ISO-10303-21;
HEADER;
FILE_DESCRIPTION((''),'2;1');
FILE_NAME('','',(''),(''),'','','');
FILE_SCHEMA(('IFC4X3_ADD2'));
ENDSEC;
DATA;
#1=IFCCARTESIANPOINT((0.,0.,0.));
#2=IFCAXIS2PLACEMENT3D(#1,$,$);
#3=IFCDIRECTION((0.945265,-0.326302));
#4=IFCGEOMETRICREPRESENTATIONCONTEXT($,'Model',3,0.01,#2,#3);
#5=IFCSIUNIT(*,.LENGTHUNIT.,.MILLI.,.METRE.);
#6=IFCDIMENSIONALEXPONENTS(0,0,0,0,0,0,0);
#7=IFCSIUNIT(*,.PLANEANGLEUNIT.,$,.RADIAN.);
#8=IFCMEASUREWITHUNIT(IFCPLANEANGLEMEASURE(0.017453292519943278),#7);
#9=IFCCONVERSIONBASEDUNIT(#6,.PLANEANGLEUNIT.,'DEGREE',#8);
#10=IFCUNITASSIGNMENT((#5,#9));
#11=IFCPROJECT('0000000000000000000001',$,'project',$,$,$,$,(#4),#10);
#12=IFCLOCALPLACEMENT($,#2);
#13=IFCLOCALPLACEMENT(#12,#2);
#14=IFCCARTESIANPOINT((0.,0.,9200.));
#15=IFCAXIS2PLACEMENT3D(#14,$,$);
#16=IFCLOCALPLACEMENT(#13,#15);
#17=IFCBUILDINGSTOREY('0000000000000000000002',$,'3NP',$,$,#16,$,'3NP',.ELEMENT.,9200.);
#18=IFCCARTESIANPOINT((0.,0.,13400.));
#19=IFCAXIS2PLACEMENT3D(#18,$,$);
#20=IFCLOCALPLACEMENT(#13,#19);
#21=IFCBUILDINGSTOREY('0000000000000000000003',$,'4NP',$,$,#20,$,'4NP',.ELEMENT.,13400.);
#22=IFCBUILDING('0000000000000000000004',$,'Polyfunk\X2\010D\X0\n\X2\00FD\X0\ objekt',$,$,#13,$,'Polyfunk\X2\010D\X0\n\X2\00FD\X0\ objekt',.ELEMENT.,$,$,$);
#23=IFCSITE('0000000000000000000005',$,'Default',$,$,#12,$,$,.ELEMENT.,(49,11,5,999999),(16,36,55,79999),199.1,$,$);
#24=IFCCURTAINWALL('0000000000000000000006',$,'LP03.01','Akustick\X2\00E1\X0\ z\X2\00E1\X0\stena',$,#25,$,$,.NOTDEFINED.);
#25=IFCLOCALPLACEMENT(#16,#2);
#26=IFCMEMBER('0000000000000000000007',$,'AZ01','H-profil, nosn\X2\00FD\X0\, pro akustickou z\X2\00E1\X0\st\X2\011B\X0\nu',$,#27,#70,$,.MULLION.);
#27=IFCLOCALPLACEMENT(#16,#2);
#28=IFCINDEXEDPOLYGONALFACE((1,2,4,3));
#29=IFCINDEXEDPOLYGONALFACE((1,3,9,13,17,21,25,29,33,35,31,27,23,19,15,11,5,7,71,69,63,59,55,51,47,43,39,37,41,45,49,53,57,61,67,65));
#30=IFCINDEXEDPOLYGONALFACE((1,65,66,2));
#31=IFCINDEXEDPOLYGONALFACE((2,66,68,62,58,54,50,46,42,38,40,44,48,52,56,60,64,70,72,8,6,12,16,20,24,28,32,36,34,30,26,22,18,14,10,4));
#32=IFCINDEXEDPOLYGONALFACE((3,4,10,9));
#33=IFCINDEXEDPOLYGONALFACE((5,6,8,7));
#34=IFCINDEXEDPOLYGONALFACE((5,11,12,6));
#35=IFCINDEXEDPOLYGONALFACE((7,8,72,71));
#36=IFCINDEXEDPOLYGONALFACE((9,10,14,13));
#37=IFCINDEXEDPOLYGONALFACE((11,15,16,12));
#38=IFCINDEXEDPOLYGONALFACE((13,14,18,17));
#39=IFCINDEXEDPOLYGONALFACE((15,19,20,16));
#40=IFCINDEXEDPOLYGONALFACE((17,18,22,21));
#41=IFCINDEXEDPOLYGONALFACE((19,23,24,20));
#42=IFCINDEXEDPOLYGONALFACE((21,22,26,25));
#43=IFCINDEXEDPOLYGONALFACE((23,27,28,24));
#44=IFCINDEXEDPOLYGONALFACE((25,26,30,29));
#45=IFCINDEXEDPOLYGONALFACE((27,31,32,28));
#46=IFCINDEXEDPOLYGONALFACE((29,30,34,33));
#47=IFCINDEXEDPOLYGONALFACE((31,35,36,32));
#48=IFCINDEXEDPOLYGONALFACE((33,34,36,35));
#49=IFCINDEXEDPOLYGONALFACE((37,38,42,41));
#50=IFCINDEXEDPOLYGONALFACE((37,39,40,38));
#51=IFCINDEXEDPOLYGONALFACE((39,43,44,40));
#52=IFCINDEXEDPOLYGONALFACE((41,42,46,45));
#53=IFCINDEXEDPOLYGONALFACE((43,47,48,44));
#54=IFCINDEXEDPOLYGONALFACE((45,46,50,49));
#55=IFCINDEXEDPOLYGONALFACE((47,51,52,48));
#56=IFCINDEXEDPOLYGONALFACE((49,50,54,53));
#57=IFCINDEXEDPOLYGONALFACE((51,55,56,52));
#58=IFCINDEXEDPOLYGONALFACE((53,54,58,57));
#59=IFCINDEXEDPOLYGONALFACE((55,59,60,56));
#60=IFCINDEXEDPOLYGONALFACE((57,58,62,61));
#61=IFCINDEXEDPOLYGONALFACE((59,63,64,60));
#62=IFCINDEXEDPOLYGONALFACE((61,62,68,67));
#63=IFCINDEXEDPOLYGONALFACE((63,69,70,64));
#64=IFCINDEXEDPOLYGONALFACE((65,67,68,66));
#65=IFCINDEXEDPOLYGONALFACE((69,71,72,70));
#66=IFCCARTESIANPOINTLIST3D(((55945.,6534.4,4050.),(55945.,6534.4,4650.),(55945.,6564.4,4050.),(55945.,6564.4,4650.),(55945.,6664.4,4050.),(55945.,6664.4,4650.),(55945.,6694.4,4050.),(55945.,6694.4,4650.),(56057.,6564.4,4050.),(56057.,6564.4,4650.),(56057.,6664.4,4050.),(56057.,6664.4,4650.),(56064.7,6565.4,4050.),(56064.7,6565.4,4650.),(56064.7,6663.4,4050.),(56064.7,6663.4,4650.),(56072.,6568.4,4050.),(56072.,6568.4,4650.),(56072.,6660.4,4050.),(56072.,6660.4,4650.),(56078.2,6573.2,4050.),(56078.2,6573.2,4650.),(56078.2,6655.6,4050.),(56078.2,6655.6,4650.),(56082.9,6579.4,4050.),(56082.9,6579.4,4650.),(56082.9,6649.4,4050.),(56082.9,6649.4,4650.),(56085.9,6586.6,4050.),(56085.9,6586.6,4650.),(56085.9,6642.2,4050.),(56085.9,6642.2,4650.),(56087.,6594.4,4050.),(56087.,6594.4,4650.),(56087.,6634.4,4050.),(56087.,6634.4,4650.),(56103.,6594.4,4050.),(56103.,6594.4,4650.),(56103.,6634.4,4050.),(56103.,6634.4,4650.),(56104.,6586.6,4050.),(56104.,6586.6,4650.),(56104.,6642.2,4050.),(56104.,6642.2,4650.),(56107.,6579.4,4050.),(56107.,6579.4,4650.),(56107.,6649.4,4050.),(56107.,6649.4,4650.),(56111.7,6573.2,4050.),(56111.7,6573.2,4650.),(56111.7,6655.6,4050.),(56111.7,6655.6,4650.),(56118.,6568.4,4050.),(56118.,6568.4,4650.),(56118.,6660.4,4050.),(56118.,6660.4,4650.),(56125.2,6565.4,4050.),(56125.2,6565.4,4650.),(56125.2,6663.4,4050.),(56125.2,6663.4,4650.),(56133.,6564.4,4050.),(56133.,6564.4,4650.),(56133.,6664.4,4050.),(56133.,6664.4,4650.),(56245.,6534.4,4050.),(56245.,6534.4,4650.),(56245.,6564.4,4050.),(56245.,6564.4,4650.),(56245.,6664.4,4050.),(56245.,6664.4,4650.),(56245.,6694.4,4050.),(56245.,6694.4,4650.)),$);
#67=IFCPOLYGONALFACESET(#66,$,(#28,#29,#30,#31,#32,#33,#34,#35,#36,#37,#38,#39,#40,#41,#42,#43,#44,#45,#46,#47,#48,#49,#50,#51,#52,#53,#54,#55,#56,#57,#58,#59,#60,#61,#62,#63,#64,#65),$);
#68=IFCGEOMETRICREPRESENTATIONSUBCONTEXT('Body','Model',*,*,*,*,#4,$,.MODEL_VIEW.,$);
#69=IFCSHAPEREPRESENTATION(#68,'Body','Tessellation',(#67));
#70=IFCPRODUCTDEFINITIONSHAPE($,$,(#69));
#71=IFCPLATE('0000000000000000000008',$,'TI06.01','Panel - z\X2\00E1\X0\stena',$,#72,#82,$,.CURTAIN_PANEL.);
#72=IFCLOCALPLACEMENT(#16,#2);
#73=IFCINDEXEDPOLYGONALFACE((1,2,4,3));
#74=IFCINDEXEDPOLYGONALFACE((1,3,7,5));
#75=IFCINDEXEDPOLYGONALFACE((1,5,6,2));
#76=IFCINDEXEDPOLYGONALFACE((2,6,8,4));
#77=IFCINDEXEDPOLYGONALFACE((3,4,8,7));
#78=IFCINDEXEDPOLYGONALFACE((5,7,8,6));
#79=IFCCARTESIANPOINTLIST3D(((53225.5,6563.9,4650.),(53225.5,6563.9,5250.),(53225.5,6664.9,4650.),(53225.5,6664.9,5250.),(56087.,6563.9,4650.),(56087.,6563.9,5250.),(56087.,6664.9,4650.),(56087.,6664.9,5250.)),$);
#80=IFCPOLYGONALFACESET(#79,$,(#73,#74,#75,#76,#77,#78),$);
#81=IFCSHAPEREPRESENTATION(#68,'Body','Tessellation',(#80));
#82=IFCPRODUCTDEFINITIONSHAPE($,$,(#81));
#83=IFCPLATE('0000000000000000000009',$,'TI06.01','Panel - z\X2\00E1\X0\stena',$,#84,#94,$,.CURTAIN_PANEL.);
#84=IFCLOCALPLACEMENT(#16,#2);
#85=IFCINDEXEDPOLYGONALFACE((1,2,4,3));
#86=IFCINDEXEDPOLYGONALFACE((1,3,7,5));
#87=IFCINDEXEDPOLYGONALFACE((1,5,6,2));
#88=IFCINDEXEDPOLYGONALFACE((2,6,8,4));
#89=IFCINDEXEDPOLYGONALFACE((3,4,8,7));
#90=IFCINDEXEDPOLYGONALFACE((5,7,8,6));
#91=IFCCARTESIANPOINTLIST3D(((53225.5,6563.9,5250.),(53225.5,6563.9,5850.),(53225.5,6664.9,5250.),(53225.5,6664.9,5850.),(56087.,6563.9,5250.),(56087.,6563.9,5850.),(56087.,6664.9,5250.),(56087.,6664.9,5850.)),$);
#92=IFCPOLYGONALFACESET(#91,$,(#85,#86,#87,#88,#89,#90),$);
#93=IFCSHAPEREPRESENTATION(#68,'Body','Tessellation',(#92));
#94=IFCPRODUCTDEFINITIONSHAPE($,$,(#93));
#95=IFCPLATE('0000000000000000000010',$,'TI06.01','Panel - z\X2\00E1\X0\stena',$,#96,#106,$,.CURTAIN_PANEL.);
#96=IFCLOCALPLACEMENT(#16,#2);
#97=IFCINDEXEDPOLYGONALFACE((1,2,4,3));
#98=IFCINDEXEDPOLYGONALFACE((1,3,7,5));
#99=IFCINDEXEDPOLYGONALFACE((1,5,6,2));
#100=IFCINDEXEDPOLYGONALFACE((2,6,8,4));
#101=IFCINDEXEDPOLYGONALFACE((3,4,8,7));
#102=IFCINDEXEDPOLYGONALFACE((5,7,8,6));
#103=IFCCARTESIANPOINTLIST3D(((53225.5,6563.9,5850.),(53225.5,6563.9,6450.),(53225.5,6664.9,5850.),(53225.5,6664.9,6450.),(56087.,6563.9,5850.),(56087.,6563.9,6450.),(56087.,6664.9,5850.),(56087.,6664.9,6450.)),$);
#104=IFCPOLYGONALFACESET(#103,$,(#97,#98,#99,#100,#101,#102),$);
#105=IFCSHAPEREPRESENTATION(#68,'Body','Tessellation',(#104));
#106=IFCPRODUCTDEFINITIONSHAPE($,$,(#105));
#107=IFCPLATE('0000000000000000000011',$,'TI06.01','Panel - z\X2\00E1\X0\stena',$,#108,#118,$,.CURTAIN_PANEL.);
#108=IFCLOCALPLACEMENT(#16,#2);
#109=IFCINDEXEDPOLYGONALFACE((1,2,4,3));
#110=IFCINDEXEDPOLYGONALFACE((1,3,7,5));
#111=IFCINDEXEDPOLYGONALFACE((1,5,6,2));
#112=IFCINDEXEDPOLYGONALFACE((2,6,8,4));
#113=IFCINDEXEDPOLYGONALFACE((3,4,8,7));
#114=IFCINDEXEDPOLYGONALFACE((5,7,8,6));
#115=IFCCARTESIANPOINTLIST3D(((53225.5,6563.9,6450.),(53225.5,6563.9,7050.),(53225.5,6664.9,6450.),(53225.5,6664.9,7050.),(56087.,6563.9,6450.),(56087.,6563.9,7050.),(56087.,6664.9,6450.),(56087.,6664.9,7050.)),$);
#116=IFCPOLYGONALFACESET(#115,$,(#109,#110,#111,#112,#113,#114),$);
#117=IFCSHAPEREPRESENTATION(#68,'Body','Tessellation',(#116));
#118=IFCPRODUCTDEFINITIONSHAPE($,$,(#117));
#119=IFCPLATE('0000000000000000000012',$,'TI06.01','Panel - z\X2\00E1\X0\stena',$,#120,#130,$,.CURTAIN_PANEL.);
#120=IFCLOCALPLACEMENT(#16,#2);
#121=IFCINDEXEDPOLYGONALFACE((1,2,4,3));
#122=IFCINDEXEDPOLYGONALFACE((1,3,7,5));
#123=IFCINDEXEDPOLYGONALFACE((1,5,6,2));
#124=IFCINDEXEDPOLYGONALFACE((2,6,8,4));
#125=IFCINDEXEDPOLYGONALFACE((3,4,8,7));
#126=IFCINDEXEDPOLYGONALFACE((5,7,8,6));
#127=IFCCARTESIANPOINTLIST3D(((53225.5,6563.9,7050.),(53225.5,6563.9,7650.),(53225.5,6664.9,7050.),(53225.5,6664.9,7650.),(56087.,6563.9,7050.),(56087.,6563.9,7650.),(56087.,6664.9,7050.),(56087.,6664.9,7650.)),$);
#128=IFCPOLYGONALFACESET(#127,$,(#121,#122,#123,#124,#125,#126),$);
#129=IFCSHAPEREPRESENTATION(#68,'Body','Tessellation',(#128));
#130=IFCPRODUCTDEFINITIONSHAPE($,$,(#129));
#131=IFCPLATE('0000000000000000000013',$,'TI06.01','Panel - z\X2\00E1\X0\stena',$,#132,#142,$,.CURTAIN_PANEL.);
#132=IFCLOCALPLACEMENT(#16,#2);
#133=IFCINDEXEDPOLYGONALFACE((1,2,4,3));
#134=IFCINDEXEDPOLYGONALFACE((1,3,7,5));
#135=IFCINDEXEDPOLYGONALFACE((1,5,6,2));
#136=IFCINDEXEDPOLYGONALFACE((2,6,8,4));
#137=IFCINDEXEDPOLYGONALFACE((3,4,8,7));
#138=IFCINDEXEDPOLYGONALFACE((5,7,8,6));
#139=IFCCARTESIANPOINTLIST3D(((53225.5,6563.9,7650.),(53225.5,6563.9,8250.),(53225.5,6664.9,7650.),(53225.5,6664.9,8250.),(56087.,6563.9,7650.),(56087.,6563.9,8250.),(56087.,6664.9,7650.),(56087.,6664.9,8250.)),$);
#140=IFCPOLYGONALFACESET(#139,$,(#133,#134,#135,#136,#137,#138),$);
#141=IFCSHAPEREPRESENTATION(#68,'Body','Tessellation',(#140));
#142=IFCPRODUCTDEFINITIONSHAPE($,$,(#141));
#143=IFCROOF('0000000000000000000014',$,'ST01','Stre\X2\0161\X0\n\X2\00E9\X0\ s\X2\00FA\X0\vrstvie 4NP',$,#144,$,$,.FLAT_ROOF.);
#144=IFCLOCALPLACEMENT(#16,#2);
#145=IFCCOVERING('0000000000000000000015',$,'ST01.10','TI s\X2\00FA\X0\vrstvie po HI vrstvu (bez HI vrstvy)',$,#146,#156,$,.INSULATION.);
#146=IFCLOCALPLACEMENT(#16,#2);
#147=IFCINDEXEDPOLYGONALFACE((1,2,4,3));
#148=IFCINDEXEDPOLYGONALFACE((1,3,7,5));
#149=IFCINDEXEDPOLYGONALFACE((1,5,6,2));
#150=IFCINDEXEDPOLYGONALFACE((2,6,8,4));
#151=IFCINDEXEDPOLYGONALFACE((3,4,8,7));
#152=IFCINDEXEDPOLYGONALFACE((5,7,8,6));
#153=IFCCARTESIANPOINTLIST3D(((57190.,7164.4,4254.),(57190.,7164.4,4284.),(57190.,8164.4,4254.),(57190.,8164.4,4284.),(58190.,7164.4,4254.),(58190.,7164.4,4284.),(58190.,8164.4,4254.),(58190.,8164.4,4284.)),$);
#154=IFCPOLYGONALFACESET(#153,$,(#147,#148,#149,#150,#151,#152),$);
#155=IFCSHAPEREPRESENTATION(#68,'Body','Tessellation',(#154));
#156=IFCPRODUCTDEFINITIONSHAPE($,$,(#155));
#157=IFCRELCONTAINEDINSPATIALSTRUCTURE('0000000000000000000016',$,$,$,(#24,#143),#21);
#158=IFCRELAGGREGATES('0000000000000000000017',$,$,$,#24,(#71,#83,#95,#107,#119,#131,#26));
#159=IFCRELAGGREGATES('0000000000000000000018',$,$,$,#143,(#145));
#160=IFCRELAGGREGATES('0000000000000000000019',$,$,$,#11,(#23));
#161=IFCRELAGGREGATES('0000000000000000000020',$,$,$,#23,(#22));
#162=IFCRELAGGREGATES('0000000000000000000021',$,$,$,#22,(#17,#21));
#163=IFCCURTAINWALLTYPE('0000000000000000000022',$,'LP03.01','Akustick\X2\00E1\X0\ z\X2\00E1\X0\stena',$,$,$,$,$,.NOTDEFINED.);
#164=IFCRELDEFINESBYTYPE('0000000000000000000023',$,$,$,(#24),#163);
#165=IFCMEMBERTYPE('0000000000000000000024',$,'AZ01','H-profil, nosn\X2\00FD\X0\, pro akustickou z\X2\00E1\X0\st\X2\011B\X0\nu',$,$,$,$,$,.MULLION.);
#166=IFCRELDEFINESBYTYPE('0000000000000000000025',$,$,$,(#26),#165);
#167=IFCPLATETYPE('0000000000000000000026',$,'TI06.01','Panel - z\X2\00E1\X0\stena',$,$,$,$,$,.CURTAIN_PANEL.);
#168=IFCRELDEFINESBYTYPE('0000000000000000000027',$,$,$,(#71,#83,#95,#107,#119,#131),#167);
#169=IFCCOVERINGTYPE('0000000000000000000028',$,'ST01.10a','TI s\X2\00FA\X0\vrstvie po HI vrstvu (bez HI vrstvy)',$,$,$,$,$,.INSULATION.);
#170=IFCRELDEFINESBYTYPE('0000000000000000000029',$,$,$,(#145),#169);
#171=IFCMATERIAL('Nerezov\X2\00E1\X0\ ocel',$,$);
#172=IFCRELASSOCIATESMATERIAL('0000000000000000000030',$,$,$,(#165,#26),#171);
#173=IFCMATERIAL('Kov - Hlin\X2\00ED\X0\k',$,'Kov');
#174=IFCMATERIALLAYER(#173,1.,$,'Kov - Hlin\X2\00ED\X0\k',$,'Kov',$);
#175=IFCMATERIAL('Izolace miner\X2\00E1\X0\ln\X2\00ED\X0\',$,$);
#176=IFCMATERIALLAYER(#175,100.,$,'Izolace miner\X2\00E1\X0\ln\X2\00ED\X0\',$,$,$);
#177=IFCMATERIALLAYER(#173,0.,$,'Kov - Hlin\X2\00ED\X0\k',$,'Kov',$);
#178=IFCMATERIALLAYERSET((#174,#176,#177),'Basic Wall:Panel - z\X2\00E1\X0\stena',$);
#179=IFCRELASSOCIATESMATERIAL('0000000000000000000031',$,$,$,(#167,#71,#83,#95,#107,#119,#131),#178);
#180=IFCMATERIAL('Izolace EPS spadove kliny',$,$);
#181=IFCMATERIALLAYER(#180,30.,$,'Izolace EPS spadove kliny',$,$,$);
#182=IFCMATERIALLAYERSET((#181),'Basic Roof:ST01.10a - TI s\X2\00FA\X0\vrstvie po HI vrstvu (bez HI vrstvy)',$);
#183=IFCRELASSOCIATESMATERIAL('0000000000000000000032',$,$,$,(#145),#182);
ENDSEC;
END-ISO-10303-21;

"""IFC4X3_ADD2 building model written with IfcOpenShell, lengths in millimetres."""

from ifc_helpers import new_model, entity, si_unit, converted_unit, direction, frame, frame_2d, origin, origin_2d_with_axis, place, context, subcontext, project, spatial, polyline, circle_curve, parameter, trimmed, segment, composite_curve, rectangle, outline, extrude, source, transform, mapped, material, layer, layer_set, layer_usage, material_profile, profile_set, profile_usage, type_object, element, aggregate, save


model = new_model("IFC4X3_ADD2")

# Units and contexts
model_context = context("Model", 3, precision=0.01, world=origin(), true_north=direction((0.945265, -0.326302)))
body_context = subcontext(model_context, "Body", "Model", "MODEL_VIEW")
ifc_project = project(units=[si_unit("LENGTHUNIT", "METRE", prefix="MILLI"), converted_unit("PLANEANGLEUNIT", "DEGREE", entity("IfcPlaneAngleMeasure", 0.017453292519943278), si_unit("PLANEANGLEUNIT", "RADIAN"), dimensions=[0, 0, 0, 0, 0, 0, 0])], contexts=[model_context])

# Site, building, storey
site_placement = place(None, origin())
site = spatial("IfcSite", under=ifc_project, at=site_placement, Name="Default", CompositionType="ELEMENT", RefLatitude=(49, 11, 5, 999999), RefLongitude=(16, 36, 55, 79999), RefElevation=199.1)
building_placement = place(site_placement, origin())
building = spatial("IfcBuilding", under=site, at=building_placement, Name="Polyfunkčný objekt", LongName="Polyfunkčný objekt", CompositionType="ELEMENT")
storey_1_placement = place(building_placement, frame((0.0, 0.0, 9200.0)))
storey_1 = spatial("IfcBuildingStorey", under=building, at=storey_1_placement, Name="3NP", LongName="3NP", CompositionType="ELEMENT", Elevation=9200.0)

# Shared definitions
storey_2_placement = place(building_placement, frame((0.0, 0.0, 13400.0)))
storey_2 = spatial("IfcBuildingStorey", under=building, at=storey_2_placement, Name="4NP", LongName="4NP", CompositionType="ELEMENT", Elevation=13400.0)

# Curtain wall, member, plates
curtain_wall_type_1 = type_object("IfcCurtainWallType", Name="LP03.01", Description="Akustická zástena", PredefinedType="NOTDEFINED")
curtain_wall_1_placement = place(storey_2_placement, frame((0.0, 0.0, -13400.0)))
curtain_wall_1 = element("IfcCurtainWall", 1, at=curtain_wall_1_placement, inside=storey_2, type_object=curtain_wall_type_1, Name="LP03.01", Description="Akustická zástena", PredefinedType="NOTDEFINED")
ifc_material_1 = material(Name="Nerezová ocel")
ifc_material_profile_1 = material_profile(ifc_material_1, outline(composite_curve([segment(polyline([(50.0, -150.0), (80.0, -150.0)]), True, "CONTINUOUS"), segment(polyline([(80.0, -150.0), (80.0, 150.0)]), True, "CONTINUOUS"), segment(polyline([(80.0, 150.0), (50.0, 150.0)]), True, "CONTINUOUS"), segment(polyline([(50.0, 150.0), (50.0, 38.0)]), True, "CONTINUOUS"), segment(trimmed(circle_curve(frame_2d((20.0, 38.0), x_axis=(0.0, 1.0)), 30.0), [parameter(180.0)], [parameter(270.0)], True, "PARAMETER"), False, "CONTINUOUS"), segment(polyline([(20.0, 8.0), (-20.0, 8.0)]), True, "CONTINUOUS"), segment(trimmed(circle_curve(frame_2d((-20.0, 38.0), x_axis=(0.0, 1.0)), 30.0), [parameter(90.0)], [parameter(180.0)], True, "PARAMETER"), False, "CONTINUOUS"), segment(polyline([(-50.0, 38.0), (-50.0, 150.0)]), True, "CONTINUOUS"), segment(polyline([(-50.0, 150.0), (-80.0, 150.0)]), True, "CONTINUOUS"), segment(polyline([(-80.0, 150.0), (-80.0, -150.0)]), True, "CONTINUOUS"), segment(polyline([(-80.0, -150.0), (-50.0, -150.0)]), True, "CONTINUOUS"), segment(polyline([(-50.0, -150.0), (-50.0, -38.0)]), True, "CONTINUOUS"), segment(trimmed(circle_curve(frame_2d((-20.0, -38.0), x_axis=(0.0, 1.0)), 30.0), [parameter(0.0)], [parameter(90.0)], True, "PARAMETER"), False, "CONTINUOUS"), segment(polyline([(-20.0, -8.0), (20.0, -8.0)]), True, "CONTINUOUS"), segment(trimmed(circle_curve(frame_2d((20.0, -38.0), x_axis=(0.0, 1.0)), 30.0), [parameter(270.0)], [parameter(0.0)], True, "PARAMETER"), False, "CONTINUOUS"), segment(polyline([(50.0, -38.0), (50.0, -150.0)]), True, "CONTINUOUS")], self_intersect=False)), Name="Profil zástena")
ifc_profile_set_1 = profile_set([ifc_material_profile_1], Name="Profil zástena")
ifc_profile_usage_1 = profile_usage(ifc_profile_set_1)
member_type_1 = type_object("IfcMemberType", Name="AZ01", Description="H-profil, nosný, pro akustickou zástěnu", PredefinedType="MULLION", material=ifc_profile_set_1)
shared_shape_1 = source(origin(), body_context, "Body", "SweptSolid", [
    extrude(outline(composite_curve([segment(polyline([(50.0, -150.0), (80.0, -150.0)]), True, "CONTINUOUS"), segment(polyline([(80.0, -150.0), (80.0, 150.0)]), True, "CONTINUOUS"), segment(polyline([(80.0, 150.0), (50.0, 150.0)]), True, "CONTINUOUS"), segment(polyline([(50.0, 150.0), (50.0, 38.0)]), True, "CONTINUOUS"), segment(trimmed(circle_curve(frame_2d((20.0, 38.0), x_axis=(0.0, 1.0)), 30.0), [parameter(180.0)], [parameter(270.0)], True, "PARAMETER"), False, "CONTINUOUS"), segment(polyline([(20.0, 8.0), (-20.0, 8.0)]), True, "CONTINUOUS"), segment(trimmed(circle_curve(frame_2d((-20.0, 38.0), x_axis=(0.0, 1.0)), 30.0), [parameter(90.0)], [parameter(180.0)], True, "PARAMETER"), False, "CONTINUOUS"), segment(polyline([(-50.0, 38.0), (-50.0, 150.0)]), True, "CONTINUOUS"), segment(polyline([(-50.0, 150.0), (-80.0, 150.0)]), True, "CONTINUOUS"), segment(polyline([(-80.0, 150.0), (-80.0, -150.0)]), True, "CONTINUOUS"), segment(polyline([(-80.0, -150.0), (-50.0, -150.0)]), True, "CONTINUOUS"), segment(polyline([(-50.0, -150.0), (-50.0, -38.0)]), True, "CONTINUOUS"), segment(trimmed(circle_curve(frame_2d((-20.0, -38.0), x_axis=(0.0, 1.0)), 30.0), [parameter(0.0)], [parameter(90.0)], True, "PARAMETER"), False, "CONTINUOUS"), segment(polyline([(-20.0, -8.0), (20.0, -8.0)]), True, "CONTINUOUS"), segment(trimmed(circle_curve(frame_2d((20.0, -38.0), x_axis=(0.0, 1.0)), 30.0), [parameter(270.0)], [parameter(0.0)], True, "PARAMETER"), False, "CONTINUOUS"), segment(polyline([(50.0, -38.0), (50.0, -150.0)]), True, "CONTINUOUS")], self_intersect=False)), frame((-150.0, 0.0, -600.0), z_axis=(0.0, 0.0, 1.0), x_axis=(0.0, -1.0, 0.0)), (0.0, 0.0, 1.0), 600.0),
])
member_1_placement = place(curtain_wall_1_placement, frame((56245.0, 6614.4, 13250.0), z_axis=(0.0, 0.0, -1.0), x_axis=(1.0, 0.0, 0.0)))
member_1 = element("IfcMember", 2, at=member_1_placement, type_object=member_type_1, material=ifc_profile_usage_1, Name="AZ01", Description="H-profil, nosný, pro akustickou zástěnu", PredefinedType="MULLION", context=body_context, shape_type="MappedRepresentation", body=[
    mapped(shared_shape_1, transform((0.0, 0.0, 0.0), scale=1.0)),
])
ifc_material_2 = material(Name="Kov - Hliník", Category="Kov")
ifc_layer_1 = layer(ifc_material_2, 1.0, Name="Kov - Hliník", Category="Kov")
ifc_material_3 = material(Name="Izolace minerální")
ifc_layer_2 = layer(ifc_material_3, 100.0, Name="Izolace minerální")
ifc_layer_3 = layer(ifc_material_2, 0.0, Name="Kov - Hliník", Category="Kov")
ifc_layer_set_1 = layer_set([ifc_layer_1, ifc_layer_2, ifc_layer_3], Name="Basic Wall:Panel - zástena")
ifc_layer_usage_1 = layer_usage(ifc_layer_set_1, "AXIS2", "POSITIVE", -50.5)
plate_type = type_object("IfcPlateType", Name="TI06.01", Description="Panel - zástena", PredefinedType="CURTAIN_PANEL", material=ifc_layer_set_1)
plate_1_placement = place(storey_2_placement, frame((53225.5, 6614.4, 450.0)))
plate_1 = element("IfcPlate", 3, at=plate_1_placement, type_object=plate_type, material=ifc_layer_usage_1, Name="TI06.01", Description="Panel - zástena", PredefinedType="CURTAIN_PANEL", context=body_context, shape_type="SweptSolid", body=[
    extrude(rectangle(XDim=101.0, YDim=2861.5, at=origin_2d_with_axis()), frame((1430.8, 0.0, 0.0), z_axis=(0.0, 0.0, 1.0), x_axis=(0.0, 1.0, 0.0)), (0.0, 0.0, 1.0), 600.0),
])
ifc_layer_usage_2 = layer_usage(ifc_layer_set_1, "AXIS2", "POSITIVE", -50.5)
plate_2_placement = place(storey_2_placement, frame((53225.5, 6614.4, 1050.0)))
plate_2 = element("IfcPlate", 4, at=plate_2_placement, type_object=plate_type, material=ifc_layer_usage_2, Name="TI06.01", Description="Panel - zástena", PredefinedType="CURTAIN_PANEL", context=body_context, shape_type="SweptSolid", body=[
    extrude(rectangle(XDim=101.0, YDim=2861.5, at=frame_2d((0.0, 0.0), x_axis=(1.0, 0.0))), frame((1430.7, 0.0, 0.0), z_axis=(0.0, 0.0, 1.0), x_axis=(0.0, 1.0, 0.0)), (0.0, 0.0, 1.0), 600.0),
])
ifc_layer_usage_3 = layer_usage(ifc_layer_set_1, "AXIS2", "POSITIVE", -50.5)
plate_3_placement = place(storey_2_placement, frame((53225.5, 6614.4, 1650.0)))
plate_3 = element("IfcPlate", 5, at=plate_3_placement, type_object=plate_type, material=ifc_layer_usage_3, Name="TI06.01", Description="Panel - zástena", PredefinedType="CURTAIN_PANEL", context=body_context, shape_type="SweptSolid", body=[
    extrude(rectangle(XDim=101.0, YDim=2861.5, at=frame_2d((0.0, 0.0), x_axis=(1.0, 0.0))), frame((1430.7, 0.0, 0.0), z_axis=(0.0, 0.0, 1.0), x_axis=(0.0, 1.0, 0.0)), (0.0, 0.0, 1.0), 600.0),
])
ifc_layer_usage_4 = layer_usage(ifc_layer_set_1, "AXIS2", "POSITIVE", -50.5)
plate_4_placement = place(storey_2_placement, frame((53225.5, 6614.4, 2250.0)))
plate_4 = element("IfcPlate", 6, at=plate_4_placement, type_object=plate_type, material=ifc_layer_usage_4, Name="TI06.01", Description="Panel - zástena", PredefinedType="CURTAIN_PANEL", context=body_context, shape_type="SweptSolid", body=[
    extrude(rectangle(XDim=101.0, YDim=2861.5, at=frame_2d((0.0, 0.0), x_axis=(1.0, 0.0))), frame((1430.7, 0.0, 0.0), z_axis=(0.0, 0.0, 1.0), x_axis=(0.0, 1.0, 0.0)), (0.0, 0.0, 1.0), 600.0),
])
ifc_layer_usage_5 = layer_usage(ifc_layer_set_1, "AXIS2", "POSITIVE", -50.5)
plate_5_placement = place(storey_2_placement, frame((53225.5, 6614.4, 2850.0)))
plate_5 = element("IfcPlate", 7, at=plate_5_placement, type_object=plate_type, material=ifc_layer_usage_5, Name="TI06.01", Description="Panel - zástena", PredefinedType="CURTAIN_PANEL", context=body_context, shape_type="SweptSolid", body=[
    extrude(rectangle(XDim=101.0, YDim=2861.5, at=frame_2d((0.0, 0.0), x_axis=(1.0, 0.0))), frame((1430.7, 0.0, 0.0), z_axis=(0.0, 0.0, 1.0), x_axis=(0.0, 1.0, 0.0)), (0.0, 0.0, 1.0), 600.0),
])
ifc_layer_usage_6 = layer_usage(ifc_layer_set_1, "AXIS2", "POSITIVE", -50.5)
plate_6_placement = place(storey_2_placement, frame((53225.5, 6614.4, 3450.0)))
plate_6 = element("IfcPlate", 8, at=plate_6_placement, type_object=plate_type, material=ifc_layer_usage_6, Name="TI06.01", Description="Panel - zástena", PredefinedType="CURTAIN_PANEL", context=body_context, shape_type="SweptSolid", body=[
    extrude(rectangle(XDim=101.0, YDim=2861.5, at=origin_2d_with_axis()), frame((1430.8, 0.0, 0.0), z_axis=(0.0, 0.0, 1.0), x_axis=(0.0, 1.0, 0.0)), (0.0, 0.0, 1.0), 600.0),
])
aggregate(curtain_wall_1, [plate_1, plate_2, plate_3, plate_4, plate_5, plate_6, member_1])

# Roof, covering
roof = element("IfcRoof", 9, inside=storey_2, Name="ST01", Description="Strešné súvrstvie 4NP", PredefinedType="FLAT_ROOF")
ifc_material_4 = material(Name="Izolace EPS spadove kliny")
ifc_layer_4 = layer(ifc_material_4, 30.0, Name="Izolace EPS spadove kliny")
ifc_layer_set_2 = layer_set([ifc_layer_4], Name="Basic Roof:ST01.10a - TI súvrstvie po HI vrstvu (bez HI vrstvy)")
covering_type_1 = type_object("IfcCoveringType", Name="ST01.10a", Description="TI súvrstvie po HI vrstvu (bez HI vrstvy)", PredefinedType="INSULATION")
placement_1 = place(storey_2_placement, frame((57190.0, 7164.4, 54.0)))
covering_1_placement = place(placement_1, origin())
covering_1 = element("IfcCovering", 10, at=covering_1_placement, type_object=covering_type_1, material=ifc_layer_set_2, Name="ST01.10", Description="TI súvrstvie po HI vrstvu (bez HI vrstvy)", PredefinedType="INSULATION", context=body_context, shape_type="SweptSolid", body=[
    extrude(rectangle(XDim=1000.0, YDim=1000.0, at=frame_2d((0.0, 0.0), x_axis=(1.0, 0.0))), frame((500.0, 500.0, 0.0)), (0.0, 0.0, 1.0), 30.0),
])
aggregate(roof, [covering_1])

save(model, "model.ifc")
